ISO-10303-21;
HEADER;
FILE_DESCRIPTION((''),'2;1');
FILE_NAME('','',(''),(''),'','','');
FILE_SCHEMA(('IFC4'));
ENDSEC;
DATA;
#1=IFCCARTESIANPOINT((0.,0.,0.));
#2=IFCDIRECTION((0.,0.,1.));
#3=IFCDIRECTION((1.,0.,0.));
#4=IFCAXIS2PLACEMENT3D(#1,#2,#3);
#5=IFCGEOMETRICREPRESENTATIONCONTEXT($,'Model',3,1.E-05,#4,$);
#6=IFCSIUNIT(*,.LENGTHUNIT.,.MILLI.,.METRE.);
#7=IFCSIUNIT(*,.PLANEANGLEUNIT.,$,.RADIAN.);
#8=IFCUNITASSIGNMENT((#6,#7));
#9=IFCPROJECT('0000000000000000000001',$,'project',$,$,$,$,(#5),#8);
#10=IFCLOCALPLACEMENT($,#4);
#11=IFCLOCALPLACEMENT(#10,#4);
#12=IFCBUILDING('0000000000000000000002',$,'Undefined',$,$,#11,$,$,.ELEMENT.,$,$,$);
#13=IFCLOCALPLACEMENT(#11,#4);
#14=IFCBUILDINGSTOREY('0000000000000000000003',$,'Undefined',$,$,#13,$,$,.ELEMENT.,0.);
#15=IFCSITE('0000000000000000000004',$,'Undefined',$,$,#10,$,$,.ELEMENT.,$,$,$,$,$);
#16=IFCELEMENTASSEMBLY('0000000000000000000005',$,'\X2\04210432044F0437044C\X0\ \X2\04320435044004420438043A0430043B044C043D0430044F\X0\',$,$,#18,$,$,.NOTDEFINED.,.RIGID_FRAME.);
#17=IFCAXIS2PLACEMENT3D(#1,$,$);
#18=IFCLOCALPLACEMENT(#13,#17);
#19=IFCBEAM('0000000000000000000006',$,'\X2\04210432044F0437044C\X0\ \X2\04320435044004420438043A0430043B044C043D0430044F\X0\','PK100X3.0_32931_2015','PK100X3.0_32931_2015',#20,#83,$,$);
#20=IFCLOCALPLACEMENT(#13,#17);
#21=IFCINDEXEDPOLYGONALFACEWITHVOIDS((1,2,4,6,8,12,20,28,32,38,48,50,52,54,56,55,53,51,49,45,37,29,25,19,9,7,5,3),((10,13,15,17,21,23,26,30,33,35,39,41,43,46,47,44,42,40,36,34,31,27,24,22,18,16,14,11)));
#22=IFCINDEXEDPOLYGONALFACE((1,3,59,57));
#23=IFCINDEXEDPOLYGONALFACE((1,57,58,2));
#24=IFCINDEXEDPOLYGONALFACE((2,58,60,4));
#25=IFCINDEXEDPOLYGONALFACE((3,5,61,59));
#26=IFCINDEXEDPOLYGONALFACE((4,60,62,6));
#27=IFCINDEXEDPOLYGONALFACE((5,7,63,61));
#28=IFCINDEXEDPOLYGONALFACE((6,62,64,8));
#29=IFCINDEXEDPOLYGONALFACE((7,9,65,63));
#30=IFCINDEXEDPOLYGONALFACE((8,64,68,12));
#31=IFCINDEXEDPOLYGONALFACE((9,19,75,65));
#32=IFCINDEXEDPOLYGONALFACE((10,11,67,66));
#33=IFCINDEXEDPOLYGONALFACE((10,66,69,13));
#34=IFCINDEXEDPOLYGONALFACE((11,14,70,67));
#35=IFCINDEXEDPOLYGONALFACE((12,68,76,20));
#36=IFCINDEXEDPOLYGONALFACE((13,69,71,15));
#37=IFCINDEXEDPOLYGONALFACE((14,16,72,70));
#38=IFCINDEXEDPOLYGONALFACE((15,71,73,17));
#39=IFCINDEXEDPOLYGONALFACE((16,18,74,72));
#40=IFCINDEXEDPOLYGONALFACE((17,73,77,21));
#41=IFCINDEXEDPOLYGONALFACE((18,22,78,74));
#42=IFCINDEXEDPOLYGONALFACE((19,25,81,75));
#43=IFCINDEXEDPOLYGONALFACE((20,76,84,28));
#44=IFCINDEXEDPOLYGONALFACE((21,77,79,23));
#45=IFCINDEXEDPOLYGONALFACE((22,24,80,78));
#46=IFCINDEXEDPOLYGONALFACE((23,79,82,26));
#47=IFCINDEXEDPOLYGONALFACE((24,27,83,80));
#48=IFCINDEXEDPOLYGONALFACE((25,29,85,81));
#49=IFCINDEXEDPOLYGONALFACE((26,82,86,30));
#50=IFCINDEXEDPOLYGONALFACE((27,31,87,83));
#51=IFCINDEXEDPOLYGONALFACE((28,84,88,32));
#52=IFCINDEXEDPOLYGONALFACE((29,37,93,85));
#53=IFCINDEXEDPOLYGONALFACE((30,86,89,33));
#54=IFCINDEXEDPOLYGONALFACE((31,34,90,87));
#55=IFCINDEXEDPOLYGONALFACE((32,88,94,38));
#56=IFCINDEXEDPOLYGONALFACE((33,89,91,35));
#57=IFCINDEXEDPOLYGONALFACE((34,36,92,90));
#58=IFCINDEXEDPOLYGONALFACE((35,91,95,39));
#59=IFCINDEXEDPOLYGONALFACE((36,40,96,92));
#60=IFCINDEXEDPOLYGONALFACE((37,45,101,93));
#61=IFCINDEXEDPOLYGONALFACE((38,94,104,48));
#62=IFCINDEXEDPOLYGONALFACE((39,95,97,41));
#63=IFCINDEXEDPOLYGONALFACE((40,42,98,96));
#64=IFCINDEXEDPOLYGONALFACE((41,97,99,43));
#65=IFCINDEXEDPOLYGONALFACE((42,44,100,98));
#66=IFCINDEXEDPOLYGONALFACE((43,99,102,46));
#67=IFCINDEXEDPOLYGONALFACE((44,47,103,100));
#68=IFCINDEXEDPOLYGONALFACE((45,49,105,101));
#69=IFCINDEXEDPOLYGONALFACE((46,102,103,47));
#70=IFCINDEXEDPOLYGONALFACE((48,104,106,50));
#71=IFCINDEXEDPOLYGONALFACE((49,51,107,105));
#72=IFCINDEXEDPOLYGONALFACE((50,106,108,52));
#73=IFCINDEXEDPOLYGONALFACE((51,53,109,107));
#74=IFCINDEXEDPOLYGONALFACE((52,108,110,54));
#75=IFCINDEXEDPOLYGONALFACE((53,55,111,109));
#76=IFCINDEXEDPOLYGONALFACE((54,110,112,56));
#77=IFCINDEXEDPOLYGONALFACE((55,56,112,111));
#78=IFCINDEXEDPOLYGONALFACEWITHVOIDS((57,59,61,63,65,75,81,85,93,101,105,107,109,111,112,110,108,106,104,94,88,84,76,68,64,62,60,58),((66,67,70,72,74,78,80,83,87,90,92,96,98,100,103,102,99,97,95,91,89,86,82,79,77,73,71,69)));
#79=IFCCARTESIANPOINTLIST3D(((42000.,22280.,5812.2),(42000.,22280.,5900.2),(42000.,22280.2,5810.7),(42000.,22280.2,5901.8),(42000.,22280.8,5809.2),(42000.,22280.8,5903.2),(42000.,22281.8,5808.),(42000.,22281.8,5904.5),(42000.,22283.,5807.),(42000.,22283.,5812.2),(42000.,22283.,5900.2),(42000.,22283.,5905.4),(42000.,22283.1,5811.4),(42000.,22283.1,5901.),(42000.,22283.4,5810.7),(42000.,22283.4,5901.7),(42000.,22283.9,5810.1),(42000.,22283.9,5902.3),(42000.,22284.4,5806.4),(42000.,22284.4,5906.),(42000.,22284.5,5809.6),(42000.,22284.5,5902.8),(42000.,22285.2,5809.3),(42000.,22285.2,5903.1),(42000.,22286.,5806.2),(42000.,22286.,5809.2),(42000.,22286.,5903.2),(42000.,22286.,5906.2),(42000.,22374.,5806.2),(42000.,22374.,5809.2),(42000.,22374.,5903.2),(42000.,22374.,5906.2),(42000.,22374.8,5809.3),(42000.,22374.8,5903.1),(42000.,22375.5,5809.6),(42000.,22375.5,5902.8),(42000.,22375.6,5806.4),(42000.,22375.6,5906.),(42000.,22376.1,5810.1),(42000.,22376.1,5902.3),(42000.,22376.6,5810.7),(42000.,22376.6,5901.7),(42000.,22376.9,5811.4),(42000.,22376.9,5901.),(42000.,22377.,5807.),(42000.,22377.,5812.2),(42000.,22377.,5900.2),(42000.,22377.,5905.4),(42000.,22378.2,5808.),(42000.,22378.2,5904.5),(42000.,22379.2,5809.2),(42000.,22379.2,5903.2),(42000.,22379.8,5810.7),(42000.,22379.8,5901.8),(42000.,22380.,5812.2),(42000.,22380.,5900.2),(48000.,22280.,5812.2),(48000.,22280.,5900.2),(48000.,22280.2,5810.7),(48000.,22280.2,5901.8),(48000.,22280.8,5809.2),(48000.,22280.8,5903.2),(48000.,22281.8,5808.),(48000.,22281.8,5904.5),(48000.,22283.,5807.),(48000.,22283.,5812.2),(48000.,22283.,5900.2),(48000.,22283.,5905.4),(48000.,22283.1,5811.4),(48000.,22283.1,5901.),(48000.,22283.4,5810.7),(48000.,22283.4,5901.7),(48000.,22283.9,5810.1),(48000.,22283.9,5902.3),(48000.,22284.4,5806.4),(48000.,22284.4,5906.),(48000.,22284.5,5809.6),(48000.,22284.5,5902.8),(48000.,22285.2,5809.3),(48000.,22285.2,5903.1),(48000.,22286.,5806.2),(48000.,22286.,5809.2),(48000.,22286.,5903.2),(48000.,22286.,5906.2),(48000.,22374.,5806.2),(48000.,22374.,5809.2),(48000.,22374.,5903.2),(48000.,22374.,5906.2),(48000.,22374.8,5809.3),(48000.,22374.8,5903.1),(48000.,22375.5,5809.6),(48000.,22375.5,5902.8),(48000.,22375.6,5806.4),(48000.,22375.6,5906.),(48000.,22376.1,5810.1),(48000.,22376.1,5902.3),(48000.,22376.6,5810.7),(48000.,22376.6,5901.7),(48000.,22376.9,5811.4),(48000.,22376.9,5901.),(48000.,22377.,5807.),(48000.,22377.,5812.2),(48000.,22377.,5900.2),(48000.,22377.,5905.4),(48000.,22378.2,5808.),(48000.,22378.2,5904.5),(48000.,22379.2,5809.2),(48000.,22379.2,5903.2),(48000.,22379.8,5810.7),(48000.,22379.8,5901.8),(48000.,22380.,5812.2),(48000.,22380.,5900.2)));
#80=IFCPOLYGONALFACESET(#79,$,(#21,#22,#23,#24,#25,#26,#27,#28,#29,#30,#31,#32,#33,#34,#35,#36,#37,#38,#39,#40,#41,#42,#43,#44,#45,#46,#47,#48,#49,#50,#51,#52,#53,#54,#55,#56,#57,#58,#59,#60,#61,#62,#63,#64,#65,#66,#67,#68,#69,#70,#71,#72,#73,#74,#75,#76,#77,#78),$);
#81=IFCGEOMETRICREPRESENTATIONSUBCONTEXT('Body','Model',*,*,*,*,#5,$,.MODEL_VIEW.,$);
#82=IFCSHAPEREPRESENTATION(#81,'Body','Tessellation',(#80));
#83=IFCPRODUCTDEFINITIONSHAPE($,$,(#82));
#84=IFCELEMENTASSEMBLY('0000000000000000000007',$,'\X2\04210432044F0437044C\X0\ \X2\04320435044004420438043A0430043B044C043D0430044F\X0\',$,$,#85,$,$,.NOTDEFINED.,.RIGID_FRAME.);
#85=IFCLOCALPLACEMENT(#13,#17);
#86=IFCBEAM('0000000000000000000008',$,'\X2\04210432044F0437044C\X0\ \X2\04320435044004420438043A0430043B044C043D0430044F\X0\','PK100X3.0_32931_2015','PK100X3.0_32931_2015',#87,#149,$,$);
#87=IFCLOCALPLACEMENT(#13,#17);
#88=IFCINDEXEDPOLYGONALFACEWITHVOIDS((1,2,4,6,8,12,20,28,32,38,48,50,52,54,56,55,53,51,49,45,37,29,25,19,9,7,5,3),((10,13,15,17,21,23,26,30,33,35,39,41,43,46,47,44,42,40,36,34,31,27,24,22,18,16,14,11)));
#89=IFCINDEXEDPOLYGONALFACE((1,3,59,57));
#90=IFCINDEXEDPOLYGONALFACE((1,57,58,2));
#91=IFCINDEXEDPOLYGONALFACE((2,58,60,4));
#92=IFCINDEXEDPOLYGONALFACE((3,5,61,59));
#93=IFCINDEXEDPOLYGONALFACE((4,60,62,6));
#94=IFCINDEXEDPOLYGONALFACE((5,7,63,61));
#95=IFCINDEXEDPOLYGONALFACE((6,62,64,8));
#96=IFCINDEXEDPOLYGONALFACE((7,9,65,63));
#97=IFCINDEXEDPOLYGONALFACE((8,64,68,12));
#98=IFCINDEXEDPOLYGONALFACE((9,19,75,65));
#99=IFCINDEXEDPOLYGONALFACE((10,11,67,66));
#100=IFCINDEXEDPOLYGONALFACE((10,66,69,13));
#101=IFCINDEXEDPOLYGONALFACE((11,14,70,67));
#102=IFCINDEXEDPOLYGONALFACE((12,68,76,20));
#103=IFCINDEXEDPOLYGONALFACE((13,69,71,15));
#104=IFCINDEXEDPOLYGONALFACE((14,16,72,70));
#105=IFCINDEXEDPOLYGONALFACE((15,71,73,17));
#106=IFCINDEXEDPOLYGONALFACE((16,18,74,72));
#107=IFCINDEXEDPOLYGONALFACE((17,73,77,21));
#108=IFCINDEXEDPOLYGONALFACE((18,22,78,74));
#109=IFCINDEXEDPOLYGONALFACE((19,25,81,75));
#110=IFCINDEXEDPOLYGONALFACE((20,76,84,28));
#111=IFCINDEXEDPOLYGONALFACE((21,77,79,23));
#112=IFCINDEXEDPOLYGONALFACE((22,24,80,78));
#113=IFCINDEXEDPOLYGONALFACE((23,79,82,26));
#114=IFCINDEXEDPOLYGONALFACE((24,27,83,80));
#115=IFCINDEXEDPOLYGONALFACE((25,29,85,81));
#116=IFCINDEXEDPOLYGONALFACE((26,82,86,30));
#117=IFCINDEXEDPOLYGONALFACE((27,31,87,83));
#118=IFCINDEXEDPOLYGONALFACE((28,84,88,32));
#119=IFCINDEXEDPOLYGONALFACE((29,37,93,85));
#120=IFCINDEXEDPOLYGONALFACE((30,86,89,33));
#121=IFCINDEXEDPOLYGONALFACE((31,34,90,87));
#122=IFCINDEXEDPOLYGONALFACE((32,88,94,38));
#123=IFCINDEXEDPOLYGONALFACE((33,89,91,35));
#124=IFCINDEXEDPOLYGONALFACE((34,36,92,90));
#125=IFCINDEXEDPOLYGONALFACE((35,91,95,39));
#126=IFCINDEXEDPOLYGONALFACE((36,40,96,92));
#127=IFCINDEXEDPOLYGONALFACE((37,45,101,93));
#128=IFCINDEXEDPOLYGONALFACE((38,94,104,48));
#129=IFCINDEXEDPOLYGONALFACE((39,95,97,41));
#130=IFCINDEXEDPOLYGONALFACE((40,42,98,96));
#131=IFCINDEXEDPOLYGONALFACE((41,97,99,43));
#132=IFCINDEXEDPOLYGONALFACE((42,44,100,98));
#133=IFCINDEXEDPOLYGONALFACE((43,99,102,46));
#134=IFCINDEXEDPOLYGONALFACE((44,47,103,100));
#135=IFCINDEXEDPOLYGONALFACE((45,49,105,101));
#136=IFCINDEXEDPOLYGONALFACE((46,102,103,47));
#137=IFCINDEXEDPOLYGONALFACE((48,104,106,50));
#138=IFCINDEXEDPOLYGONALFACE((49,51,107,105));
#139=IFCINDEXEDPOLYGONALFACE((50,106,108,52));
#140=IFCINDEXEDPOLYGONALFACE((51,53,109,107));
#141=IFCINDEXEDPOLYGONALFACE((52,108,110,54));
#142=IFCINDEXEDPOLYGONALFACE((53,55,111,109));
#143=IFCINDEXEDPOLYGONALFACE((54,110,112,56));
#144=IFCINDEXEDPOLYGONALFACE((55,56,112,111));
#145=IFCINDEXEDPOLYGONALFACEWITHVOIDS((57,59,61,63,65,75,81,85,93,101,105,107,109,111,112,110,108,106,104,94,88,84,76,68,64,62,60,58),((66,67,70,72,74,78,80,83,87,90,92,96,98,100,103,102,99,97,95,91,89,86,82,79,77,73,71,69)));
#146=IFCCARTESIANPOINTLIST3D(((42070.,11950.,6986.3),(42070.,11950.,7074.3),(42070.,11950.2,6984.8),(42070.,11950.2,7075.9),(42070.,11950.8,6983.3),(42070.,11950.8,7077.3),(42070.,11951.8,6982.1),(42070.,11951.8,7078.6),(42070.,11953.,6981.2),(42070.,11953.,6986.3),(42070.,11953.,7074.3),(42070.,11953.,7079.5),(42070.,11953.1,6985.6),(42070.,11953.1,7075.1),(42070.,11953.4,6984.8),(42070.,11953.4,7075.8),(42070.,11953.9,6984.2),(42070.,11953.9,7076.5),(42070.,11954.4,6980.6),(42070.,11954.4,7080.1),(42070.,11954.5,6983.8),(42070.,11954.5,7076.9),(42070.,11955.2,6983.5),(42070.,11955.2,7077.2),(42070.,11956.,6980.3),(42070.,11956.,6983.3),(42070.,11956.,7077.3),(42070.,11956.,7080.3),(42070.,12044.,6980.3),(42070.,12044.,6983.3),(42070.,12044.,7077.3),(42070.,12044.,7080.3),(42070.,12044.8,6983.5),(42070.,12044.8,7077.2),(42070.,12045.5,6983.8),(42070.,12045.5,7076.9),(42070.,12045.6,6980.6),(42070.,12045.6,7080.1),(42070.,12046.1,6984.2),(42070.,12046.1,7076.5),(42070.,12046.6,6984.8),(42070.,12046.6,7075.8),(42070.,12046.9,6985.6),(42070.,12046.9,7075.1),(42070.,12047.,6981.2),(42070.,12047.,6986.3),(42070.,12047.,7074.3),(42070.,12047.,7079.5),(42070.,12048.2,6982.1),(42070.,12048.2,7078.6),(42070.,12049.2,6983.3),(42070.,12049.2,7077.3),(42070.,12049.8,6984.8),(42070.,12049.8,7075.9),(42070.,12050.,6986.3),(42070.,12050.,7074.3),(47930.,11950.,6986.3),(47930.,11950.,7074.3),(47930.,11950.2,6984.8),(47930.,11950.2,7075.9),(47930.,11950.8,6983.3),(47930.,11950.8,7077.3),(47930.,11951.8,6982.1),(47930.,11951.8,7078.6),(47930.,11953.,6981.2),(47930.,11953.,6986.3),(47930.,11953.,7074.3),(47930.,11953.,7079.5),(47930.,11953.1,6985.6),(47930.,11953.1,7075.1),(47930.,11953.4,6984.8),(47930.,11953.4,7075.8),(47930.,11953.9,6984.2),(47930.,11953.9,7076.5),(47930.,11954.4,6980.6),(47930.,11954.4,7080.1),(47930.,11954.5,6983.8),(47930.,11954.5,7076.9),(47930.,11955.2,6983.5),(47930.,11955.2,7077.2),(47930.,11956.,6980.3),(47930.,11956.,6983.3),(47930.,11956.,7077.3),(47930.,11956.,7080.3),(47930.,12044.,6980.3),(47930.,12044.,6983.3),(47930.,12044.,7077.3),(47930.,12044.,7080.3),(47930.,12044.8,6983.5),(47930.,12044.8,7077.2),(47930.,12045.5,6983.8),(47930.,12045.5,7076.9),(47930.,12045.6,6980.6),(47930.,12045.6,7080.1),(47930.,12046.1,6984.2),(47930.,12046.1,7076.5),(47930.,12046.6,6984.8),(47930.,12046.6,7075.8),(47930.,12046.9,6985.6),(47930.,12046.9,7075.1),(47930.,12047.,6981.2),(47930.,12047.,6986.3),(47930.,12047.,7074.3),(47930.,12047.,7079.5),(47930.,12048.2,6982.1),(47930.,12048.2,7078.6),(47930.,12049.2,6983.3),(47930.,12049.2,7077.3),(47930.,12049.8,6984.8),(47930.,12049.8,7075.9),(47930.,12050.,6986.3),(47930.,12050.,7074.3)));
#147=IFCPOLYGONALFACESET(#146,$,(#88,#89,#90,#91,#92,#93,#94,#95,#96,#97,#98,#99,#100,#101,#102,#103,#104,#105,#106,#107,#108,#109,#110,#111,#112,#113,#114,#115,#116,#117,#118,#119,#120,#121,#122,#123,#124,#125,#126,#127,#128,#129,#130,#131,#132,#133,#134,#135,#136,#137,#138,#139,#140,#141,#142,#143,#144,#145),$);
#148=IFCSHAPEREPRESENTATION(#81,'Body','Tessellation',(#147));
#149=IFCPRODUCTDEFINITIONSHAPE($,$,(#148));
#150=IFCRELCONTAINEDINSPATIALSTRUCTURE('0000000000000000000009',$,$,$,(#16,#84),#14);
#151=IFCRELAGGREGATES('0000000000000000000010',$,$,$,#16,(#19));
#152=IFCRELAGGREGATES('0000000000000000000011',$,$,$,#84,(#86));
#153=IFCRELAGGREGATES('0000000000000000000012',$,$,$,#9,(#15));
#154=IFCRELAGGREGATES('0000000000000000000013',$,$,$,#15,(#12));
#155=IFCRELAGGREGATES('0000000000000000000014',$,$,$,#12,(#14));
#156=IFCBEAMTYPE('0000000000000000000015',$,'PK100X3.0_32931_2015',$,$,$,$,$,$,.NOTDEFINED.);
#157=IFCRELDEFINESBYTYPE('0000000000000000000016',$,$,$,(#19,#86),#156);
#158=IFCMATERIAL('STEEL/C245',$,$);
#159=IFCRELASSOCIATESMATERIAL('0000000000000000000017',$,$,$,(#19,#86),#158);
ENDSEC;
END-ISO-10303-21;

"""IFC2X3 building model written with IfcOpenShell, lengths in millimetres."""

from ifc_helpers import new_model, si_unit, frame, origin_with_axes, origin_2d_with_axis, place, context, subcontext, project, spatial, hollow_rectangle, extrude, material, type_object, element, aggregate, save


model = new_model("IFC2X3")

# Units and contexts
model_context = context("Model", 3, precision=1e-05, world=origin_with_axes())
body_context = subcontext(model_context, "Body", "Model", "MODEL_VIEW")
ifc_project = project(units=[si_unit("LENGTHUNIT", "METRE", prefix="MILLI"), si_unit("PLANEANGLEUNIT", "RADIAN")], contexts=[model_context])

# Site, building, storey
site_placement = place(None, origin_with_axes())
site = spatial("IfcSite", under=ifc_project, at=site_placement, Name="Undefined", CompositionType="ELEMENT")
building_placement = place(site_placement, origin_with_axes())
building = spatial("IfcBuilding", under=site, at=building_placement, Name="Undefined", CompositionType="ELEMENT")
storey_placement = place(building_placement, origin_with_axes())
storey = spatial("IfcBuildingStorey", under=building, at=storey_placement, Name="Undefined", CompositionType="ELEMENT", Elevation=0.0)

# Element assemblies, beams
assembly_1_placement = place(storey_placement, origin_with_axes())
assembly_1 = element("IfcElementAssembly", 1, at=assembly_1_placement, inside=storey, Name="Связь вертикальная", AssemblyPlace="NOTDEFINED", PredefinedType="RIGID_FRAME")
ifc_material_1 = material(Name="STEEL/C245")
beam_type_1 = type_object("IfcBeamType", Name="PK100X3.0_32931_2015", PredefinedType="NOTDEFINED")
beam_1_placement = place(assembly_1_placement, frame((42000.0, 22330.0, 5856.2), z_axis=(0.0, 0.0, 1.0), x_axis=(1.0, 0.0, 0.0)))
beam_1 = element("IfcBeam", 2, at=beam_1_placement, type_object=beam_type_1, material=ifc_material_1, Name="Связь вертикальная", Description="PK100X3.0_32931_2015", ObjectType="PK100X3.0_32931_2015", context=body_context, shape_type="SweptSolid", body=[
    extrude(hollow_rectangle(XDim=100.0, YDim=100.0, WallThickness=3.0, InnerFilletRadius=3.0, OuterFilletRadius=6.0, at=origin_2d_with_axis()), frame((6000.0, 0.0, 0.0), z_axis=(-1.0, 0.0, 0.0), x_axis=(0.0, -1.0, 0.0)), (0.0, 0.0, 1.0), 6000.0),
])
aggregate(assembly_1, [beam_1])
assembly_2_placement = place(storey_placement, origin_with_axes())
assembly_2 = element("IfcElementAssembly", 3, at=assembly_2_placement, inside=storey, Name="Связь вертикальная", AssemblyPlace="NOTDEFINED", PredefinedType="RIGID_FRAME")
beam_2_placement = place(assembly_2_placement, frame((42070.0, 12000.0, 7030.3), z_axis=(0.0, 0.0, 1.0), x_axis=(1.0, 0.0, 0.0)))
beam_2 = element("IfcBeam", 4, at=beam_2_placement, type_object=beam_type_1, material=ifc_material_1, Name="Связь вертикальная", Description="PK100X3.0_32931_2015", ObjectType="PK100X3.0_32931_2015", context=body_context, shape_type="SweptSolid", body=[
    extrude(hollow_rectangle(XDim=100.0, YDim=100.0, WallThickness=3.0, InnerFilletRadius=3.0, OuterFilletRadius=6.0, at=origin_2d_with_axis()), frame((5860.0, 0.0, 0.0), z_axis=(-1.0, 0.0, 0.0), x_axis=(0.0, -1.0, 0.0)), (0.0, 0.0, 1.0), 5860.0),
])
aggregate(assembly_2, [beam_2])

save(model, "model.ifc")
